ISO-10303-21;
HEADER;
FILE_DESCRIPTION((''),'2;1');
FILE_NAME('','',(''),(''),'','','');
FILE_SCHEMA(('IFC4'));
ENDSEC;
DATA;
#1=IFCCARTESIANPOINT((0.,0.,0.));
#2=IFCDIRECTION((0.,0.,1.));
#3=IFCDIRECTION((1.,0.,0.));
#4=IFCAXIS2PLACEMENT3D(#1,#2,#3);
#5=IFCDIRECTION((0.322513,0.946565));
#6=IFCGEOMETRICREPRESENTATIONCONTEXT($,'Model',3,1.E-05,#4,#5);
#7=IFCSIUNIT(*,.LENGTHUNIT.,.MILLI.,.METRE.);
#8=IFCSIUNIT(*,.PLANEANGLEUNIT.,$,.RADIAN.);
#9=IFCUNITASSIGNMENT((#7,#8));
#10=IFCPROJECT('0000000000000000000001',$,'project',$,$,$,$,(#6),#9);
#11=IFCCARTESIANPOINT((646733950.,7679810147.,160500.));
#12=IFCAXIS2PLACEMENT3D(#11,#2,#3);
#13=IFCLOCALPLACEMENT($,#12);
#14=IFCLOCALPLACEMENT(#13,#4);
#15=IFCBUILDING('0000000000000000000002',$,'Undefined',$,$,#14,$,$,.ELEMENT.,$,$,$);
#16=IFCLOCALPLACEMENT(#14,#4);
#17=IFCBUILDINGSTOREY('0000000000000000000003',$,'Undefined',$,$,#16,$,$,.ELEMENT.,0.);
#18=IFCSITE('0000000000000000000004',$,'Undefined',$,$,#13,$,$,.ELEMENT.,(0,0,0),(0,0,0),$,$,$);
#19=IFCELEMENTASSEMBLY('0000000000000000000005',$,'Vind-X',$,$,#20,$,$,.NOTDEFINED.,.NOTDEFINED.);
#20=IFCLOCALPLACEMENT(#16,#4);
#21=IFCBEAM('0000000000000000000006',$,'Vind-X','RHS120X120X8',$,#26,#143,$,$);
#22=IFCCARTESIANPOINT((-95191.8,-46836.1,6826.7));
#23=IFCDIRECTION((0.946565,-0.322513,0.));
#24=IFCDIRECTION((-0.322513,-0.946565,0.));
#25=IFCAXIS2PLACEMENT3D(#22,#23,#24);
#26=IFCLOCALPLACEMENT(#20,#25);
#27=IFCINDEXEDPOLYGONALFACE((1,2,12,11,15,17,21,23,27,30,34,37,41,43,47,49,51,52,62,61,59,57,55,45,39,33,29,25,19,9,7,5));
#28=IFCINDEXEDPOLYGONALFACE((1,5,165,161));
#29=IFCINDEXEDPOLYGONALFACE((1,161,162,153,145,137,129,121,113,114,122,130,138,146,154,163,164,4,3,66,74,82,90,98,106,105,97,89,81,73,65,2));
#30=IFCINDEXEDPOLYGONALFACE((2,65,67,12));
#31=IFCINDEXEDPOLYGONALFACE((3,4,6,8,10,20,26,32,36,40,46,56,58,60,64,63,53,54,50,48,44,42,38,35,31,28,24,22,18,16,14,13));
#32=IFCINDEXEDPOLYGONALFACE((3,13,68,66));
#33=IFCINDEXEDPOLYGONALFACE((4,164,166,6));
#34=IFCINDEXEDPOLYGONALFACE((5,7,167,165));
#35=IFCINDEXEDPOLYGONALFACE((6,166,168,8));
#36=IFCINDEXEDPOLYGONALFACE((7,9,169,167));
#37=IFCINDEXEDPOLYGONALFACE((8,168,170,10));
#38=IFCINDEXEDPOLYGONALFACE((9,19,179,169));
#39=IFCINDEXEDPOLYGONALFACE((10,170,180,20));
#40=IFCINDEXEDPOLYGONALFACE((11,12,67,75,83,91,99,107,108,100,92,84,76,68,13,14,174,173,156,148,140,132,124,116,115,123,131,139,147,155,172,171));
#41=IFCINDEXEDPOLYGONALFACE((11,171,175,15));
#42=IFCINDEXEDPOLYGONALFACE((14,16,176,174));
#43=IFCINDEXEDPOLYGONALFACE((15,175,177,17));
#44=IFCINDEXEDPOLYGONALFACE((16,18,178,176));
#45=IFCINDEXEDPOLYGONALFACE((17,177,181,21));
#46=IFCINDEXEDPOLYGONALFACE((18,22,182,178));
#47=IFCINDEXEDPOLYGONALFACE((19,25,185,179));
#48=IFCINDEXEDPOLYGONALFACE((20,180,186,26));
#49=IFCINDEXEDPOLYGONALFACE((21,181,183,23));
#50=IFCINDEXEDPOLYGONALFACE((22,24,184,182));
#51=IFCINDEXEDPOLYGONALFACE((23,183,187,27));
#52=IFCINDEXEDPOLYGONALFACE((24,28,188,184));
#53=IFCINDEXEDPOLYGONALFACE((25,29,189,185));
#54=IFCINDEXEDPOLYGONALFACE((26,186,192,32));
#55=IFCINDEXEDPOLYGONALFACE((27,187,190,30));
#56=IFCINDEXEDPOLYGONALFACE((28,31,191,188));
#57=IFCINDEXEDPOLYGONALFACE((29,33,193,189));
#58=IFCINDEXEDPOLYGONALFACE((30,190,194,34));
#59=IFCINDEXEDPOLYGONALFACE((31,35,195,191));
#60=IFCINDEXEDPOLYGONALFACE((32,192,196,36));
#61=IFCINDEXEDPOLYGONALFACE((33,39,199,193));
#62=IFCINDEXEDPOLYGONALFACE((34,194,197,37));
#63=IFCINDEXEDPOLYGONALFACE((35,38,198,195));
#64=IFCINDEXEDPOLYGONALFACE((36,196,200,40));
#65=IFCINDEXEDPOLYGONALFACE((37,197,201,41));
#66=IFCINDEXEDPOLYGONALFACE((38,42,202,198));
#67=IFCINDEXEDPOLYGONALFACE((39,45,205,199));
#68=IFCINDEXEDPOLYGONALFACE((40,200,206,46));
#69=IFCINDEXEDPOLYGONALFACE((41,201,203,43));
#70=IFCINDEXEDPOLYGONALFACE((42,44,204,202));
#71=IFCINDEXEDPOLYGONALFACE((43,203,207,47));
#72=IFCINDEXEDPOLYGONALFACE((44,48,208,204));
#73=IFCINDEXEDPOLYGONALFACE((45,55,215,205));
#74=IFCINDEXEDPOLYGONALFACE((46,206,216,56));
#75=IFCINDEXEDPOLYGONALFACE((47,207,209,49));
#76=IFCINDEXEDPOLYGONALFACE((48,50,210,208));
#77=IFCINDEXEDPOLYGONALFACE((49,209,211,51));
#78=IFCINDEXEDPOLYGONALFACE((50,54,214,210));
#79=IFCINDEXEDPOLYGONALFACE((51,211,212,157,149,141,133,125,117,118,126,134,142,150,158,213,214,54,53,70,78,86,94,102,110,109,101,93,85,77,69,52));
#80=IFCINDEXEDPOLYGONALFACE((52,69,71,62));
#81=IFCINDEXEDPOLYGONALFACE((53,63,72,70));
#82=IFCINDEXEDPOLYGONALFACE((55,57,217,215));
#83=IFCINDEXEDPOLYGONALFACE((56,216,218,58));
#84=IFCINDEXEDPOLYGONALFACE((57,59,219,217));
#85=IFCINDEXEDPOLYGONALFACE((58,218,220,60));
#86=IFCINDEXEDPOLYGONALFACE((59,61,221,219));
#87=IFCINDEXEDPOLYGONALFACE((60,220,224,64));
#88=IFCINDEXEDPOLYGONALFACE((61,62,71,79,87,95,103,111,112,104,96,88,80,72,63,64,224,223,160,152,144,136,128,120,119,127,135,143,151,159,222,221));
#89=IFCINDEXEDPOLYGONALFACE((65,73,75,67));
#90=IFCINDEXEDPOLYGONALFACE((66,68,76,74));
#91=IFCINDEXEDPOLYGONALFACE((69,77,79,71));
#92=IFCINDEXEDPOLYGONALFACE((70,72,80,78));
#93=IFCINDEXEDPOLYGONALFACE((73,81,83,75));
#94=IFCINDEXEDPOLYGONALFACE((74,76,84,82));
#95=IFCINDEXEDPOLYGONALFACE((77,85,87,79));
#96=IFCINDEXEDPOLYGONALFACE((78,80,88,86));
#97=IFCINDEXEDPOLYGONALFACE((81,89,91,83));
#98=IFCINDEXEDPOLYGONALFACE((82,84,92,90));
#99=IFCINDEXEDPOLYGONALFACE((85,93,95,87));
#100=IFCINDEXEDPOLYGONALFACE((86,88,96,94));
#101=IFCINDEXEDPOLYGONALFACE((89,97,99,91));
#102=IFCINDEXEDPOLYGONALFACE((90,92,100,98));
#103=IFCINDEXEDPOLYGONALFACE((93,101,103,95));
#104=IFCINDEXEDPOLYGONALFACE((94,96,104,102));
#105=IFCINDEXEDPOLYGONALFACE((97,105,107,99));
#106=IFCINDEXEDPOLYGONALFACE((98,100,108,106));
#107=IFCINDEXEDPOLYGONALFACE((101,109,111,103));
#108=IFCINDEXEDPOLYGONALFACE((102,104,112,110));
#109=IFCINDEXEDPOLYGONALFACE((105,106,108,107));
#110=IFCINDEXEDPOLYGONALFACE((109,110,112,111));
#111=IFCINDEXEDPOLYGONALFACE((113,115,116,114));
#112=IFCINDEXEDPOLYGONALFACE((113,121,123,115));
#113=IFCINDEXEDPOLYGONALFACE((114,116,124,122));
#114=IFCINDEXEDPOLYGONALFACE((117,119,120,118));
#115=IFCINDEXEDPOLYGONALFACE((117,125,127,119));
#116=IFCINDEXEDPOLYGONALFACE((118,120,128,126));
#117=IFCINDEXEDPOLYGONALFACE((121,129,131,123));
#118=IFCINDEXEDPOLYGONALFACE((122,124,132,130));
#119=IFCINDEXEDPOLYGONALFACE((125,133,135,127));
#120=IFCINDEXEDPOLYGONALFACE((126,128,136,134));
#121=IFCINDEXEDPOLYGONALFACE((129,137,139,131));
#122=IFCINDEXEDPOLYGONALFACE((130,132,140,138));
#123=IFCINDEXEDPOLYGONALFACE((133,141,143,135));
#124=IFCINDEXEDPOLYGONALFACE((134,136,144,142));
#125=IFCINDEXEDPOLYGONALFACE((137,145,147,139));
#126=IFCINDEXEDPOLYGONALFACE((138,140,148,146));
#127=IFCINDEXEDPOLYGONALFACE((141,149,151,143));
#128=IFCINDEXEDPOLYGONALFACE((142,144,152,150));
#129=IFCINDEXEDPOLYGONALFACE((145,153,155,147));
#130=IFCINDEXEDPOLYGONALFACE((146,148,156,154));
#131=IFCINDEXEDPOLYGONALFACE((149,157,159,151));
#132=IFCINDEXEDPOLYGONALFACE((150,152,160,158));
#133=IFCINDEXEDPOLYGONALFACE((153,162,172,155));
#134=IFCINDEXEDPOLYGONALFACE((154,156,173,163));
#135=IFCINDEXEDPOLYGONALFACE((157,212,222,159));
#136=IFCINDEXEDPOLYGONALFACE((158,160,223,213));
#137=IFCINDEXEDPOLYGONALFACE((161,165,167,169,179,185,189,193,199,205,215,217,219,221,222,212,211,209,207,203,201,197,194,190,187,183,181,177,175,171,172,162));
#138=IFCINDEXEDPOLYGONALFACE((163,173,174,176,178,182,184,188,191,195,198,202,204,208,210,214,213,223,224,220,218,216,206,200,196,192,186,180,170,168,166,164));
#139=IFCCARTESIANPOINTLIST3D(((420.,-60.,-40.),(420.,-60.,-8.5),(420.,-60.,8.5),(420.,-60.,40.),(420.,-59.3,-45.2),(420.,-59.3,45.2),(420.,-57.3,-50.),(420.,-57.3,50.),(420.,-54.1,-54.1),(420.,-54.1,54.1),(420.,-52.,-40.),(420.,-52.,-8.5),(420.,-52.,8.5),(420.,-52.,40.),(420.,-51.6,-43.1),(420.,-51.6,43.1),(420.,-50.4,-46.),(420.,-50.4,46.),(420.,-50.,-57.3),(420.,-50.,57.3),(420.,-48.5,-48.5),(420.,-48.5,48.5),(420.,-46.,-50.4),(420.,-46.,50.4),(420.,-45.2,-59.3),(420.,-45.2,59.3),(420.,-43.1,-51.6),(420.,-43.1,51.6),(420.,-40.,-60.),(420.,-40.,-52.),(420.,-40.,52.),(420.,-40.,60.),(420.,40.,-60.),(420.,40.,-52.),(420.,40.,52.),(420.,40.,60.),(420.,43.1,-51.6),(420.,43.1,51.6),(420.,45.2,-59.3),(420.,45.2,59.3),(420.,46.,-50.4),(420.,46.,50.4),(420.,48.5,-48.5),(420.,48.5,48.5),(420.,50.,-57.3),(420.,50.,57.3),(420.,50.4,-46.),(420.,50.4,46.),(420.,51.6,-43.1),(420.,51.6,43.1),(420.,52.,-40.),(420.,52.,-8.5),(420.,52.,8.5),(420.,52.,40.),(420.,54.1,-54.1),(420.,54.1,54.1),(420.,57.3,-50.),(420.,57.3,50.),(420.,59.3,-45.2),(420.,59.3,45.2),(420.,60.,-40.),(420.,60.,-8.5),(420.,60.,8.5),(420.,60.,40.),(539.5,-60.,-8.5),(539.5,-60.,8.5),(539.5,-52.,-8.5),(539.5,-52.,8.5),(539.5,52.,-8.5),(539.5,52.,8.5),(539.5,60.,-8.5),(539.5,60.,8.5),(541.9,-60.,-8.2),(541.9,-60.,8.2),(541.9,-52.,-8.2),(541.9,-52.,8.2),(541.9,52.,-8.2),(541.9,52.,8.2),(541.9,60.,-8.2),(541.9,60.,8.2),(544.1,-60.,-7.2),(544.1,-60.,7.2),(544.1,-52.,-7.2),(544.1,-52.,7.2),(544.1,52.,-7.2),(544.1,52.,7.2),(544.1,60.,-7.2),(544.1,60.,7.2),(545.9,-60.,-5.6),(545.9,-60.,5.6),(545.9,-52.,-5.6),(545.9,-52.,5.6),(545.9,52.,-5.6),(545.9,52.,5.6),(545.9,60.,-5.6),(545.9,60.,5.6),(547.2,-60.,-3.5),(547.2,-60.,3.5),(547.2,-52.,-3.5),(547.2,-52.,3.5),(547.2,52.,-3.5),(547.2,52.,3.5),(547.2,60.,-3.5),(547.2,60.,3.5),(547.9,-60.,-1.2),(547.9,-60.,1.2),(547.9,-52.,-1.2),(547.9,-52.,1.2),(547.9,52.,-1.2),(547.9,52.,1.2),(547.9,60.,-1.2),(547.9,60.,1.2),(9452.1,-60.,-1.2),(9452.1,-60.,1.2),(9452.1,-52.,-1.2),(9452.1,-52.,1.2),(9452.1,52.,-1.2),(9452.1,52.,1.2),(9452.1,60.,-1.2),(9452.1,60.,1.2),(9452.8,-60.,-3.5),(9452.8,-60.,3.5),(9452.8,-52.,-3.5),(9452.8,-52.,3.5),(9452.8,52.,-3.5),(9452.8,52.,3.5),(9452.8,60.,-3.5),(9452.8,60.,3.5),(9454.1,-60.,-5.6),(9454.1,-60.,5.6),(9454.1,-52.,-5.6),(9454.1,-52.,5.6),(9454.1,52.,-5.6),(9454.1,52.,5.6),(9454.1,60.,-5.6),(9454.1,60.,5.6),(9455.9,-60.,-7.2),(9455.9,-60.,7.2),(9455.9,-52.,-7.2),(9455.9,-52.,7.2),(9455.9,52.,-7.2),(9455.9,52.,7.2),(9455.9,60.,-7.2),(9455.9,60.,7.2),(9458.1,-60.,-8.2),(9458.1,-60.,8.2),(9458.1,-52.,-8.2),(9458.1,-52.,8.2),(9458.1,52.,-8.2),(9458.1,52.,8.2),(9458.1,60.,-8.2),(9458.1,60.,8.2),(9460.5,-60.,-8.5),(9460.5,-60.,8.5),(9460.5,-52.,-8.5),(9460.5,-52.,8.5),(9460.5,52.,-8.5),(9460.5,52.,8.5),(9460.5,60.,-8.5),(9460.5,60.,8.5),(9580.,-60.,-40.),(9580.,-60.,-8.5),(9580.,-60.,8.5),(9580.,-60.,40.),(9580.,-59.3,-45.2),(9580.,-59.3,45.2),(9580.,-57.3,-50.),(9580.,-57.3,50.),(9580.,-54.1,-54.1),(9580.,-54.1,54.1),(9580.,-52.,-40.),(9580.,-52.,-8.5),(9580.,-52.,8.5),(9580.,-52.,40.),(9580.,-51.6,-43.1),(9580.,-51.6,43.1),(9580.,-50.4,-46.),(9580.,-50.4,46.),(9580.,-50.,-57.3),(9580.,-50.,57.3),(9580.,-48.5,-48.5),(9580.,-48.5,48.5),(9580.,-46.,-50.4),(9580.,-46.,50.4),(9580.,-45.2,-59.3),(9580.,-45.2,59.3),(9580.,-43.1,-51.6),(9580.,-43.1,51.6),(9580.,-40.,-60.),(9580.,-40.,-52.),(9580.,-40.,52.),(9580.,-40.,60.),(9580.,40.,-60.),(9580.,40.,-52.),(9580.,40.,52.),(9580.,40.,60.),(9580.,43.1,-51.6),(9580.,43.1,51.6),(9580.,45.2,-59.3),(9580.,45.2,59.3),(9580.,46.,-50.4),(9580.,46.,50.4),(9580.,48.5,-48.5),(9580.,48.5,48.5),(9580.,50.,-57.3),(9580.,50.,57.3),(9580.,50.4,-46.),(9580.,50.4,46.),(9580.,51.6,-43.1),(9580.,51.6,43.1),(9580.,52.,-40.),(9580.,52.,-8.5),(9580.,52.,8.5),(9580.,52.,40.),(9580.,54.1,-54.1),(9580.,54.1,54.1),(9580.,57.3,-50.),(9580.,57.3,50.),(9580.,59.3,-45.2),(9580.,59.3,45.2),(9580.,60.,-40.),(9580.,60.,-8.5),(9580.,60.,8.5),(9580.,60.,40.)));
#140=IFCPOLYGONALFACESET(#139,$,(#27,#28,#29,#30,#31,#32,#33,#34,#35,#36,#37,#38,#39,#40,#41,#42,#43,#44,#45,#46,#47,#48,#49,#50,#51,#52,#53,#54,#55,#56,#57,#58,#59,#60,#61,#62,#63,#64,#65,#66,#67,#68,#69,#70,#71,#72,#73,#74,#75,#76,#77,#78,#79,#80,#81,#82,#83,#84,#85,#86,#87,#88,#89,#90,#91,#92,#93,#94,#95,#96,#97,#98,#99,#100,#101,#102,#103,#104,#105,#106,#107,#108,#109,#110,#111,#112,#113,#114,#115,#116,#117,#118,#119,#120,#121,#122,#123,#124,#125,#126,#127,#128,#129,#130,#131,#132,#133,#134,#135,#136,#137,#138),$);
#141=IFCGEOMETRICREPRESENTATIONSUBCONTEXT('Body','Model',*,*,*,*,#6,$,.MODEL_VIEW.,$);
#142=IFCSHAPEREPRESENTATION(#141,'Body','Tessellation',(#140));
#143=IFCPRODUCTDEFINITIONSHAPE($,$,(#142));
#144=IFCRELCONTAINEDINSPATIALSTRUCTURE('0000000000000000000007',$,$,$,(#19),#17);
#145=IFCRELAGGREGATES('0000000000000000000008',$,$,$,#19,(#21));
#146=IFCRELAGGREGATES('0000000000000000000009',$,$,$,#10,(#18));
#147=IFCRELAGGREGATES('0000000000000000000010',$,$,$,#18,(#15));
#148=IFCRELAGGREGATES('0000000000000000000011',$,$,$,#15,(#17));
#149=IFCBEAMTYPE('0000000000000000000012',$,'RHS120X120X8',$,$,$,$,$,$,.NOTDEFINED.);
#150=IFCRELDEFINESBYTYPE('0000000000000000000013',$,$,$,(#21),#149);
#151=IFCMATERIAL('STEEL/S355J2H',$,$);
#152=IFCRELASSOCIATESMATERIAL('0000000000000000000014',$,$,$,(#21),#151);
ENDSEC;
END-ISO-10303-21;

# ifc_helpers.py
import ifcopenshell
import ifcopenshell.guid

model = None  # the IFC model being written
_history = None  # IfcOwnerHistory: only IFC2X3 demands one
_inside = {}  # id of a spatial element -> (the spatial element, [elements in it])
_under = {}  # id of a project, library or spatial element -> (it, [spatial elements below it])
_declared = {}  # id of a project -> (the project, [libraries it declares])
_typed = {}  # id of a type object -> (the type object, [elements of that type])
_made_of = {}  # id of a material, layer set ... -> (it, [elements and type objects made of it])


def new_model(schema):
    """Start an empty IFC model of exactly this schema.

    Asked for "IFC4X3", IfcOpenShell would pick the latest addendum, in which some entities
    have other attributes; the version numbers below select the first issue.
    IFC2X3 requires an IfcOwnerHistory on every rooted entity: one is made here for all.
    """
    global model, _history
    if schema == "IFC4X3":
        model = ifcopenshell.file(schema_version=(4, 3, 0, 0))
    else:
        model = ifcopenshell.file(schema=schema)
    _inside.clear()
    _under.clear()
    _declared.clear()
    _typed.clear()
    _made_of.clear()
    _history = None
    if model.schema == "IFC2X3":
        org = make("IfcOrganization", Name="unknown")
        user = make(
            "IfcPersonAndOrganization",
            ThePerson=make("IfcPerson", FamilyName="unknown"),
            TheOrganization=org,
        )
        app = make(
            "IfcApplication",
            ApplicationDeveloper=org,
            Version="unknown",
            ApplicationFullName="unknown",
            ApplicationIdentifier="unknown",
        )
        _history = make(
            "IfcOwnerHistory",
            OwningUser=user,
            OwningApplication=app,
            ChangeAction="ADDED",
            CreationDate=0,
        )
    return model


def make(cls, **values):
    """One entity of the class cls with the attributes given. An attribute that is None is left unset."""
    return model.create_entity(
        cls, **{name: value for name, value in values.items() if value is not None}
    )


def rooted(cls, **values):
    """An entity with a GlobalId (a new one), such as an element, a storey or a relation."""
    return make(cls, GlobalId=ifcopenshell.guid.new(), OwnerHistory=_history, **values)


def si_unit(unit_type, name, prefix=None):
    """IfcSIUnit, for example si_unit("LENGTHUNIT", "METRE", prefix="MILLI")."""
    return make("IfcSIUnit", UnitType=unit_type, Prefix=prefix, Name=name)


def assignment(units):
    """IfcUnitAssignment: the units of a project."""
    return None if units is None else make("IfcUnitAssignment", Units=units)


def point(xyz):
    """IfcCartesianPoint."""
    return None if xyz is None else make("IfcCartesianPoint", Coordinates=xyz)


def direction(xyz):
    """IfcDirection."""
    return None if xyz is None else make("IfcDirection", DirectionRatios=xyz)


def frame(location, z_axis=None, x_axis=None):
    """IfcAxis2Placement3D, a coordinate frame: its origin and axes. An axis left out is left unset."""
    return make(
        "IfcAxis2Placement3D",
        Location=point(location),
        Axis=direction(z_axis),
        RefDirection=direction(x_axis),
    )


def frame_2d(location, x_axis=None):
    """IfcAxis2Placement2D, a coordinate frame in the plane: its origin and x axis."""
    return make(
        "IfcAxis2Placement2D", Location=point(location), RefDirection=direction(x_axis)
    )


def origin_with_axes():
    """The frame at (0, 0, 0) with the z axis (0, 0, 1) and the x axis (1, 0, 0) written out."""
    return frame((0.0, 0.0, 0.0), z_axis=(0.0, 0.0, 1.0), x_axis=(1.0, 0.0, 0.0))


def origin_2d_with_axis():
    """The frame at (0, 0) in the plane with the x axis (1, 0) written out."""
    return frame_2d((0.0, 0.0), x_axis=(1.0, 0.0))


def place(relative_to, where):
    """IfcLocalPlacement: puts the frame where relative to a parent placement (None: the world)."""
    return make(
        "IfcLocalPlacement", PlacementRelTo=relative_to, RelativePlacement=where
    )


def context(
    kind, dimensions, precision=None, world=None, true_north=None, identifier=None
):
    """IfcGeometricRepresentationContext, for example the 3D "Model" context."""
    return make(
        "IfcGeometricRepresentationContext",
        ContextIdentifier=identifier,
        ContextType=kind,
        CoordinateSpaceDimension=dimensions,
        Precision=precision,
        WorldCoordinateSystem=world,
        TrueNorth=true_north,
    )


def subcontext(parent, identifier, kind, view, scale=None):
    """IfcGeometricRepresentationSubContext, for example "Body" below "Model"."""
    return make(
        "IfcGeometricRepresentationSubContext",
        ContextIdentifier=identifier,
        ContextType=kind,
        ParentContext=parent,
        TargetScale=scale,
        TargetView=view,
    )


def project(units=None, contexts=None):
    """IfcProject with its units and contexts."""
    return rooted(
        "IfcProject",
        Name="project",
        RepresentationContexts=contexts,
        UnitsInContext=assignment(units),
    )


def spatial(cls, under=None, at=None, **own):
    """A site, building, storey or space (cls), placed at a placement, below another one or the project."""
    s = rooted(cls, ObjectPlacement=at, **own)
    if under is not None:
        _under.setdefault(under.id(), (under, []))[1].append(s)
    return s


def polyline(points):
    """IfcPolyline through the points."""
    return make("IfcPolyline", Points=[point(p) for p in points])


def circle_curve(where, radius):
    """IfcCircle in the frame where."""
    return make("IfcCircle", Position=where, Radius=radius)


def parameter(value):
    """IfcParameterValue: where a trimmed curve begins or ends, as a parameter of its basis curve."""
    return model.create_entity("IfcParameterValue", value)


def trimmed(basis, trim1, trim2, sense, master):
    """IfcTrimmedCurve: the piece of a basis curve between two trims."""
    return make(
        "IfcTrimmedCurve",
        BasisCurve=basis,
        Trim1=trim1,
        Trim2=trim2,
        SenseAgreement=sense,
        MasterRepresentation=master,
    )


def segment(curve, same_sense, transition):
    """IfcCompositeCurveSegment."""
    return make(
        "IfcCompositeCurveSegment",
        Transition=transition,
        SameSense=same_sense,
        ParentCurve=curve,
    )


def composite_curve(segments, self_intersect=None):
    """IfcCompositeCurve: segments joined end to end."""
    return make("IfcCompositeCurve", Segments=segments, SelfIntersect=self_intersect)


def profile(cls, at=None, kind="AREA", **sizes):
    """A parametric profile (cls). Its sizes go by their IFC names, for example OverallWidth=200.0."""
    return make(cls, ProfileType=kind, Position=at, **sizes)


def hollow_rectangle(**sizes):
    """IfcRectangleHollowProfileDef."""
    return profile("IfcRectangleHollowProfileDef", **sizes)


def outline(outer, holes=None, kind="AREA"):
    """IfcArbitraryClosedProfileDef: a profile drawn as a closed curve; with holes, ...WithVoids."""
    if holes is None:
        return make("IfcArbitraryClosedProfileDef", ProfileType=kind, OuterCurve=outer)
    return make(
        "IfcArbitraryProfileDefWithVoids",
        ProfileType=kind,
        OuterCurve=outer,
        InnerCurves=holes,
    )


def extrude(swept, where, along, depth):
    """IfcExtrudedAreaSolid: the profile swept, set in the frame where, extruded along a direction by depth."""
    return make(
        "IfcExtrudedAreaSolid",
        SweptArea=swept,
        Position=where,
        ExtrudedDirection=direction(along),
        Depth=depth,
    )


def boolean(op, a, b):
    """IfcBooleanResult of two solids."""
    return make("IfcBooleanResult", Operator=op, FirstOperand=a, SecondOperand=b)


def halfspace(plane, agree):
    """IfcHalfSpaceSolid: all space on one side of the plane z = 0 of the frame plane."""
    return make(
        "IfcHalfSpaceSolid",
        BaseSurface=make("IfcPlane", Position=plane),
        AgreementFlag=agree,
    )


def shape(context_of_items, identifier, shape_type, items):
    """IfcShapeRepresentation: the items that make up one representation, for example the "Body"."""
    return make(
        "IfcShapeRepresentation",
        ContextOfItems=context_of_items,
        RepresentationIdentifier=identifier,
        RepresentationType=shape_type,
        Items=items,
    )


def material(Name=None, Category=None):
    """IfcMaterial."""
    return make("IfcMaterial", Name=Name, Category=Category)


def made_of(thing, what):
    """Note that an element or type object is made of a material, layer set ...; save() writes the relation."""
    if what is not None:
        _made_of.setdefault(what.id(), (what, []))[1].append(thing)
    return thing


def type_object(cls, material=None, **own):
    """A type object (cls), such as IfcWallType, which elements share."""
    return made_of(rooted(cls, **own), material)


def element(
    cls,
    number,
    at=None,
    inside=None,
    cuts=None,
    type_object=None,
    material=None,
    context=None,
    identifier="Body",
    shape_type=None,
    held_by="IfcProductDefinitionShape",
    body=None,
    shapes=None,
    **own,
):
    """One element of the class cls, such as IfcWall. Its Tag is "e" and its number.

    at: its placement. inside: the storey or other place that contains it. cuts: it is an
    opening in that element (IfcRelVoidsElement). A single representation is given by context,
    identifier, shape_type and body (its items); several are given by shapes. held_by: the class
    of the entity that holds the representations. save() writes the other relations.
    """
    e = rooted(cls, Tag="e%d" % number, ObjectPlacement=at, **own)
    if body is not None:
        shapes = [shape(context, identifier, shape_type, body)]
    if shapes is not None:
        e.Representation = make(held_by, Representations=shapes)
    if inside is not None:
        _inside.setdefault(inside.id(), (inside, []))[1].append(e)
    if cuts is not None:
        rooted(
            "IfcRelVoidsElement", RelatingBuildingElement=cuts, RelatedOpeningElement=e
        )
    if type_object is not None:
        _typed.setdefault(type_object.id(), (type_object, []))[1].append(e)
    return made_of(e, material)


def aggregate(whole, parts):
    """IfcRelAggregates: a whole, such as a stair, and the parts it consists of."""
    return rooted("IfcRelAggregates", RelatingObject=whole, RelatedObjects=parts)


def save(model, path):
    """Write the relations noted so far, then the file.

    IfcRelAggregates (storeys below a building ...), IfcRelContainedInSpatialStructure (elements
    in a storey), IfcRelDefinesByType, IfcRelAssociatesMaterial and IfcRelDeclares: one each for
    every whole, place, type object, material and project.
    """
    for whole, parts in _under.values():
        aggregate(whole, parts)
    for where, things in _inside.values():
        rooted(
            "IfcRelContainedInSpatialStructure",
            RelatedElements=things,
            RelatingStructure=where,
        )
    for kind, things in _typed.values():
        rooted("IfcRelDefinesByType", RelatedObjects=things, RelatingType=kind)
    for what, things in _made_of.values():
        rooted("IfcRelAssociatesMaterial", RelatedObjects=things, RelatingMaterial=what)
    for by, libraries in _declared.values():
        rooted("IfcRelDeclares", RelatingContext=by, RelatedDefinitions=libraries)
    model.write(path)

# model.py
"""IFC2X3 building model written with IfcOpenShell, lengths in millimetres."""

from ifc_helpers import new_model, si_unit, direction, frame, frame_2d, origin_with_axes, origin_2d_with_axis, place, context, subcontext, project, spatial, polyline, circle_curve, parameter, trimmed, segment, composite_curve, hollow_rectangle, outline, extrude, boolean, halfspace, material, type_object, element, aggregate, save


model = new_model("IFC2X3")

# Units and contexts
model_context = context("Model", 3, precision=1e-05, world=origin_with_axes(), true_north=direction((0.322513, 0.946565)))
body_context = subcontext(model_context, "Body", "Model", "MODEL_VIEW")
ifc_project = project(units=[si_unit("LENGTHUNIT", "METRE", prefix="MILLI"), si_unit("PLANEANGLEUNIT", "RADIAN")], contexts=[model_context])

# Site, building, storey
site_placement = place(None, frame((646733950.0, 7679810147.0, 160500.0), z_axis=(0.0, 0.0, 1.0), x_axis=(1.0, 0.0, 0.0)))
site = spatial("IfcSite", under=ifc_project, at=site_placement, Name="Undefined", CompositionType="ELEMENT", RefLatitude=(0, 0, 0), RefLongitude=(0, 0, 0))
building_placement = place(site_placement, origin_with_axes())
building = spatial("IfcBuilding", under=site, at=building_placement, Name="Undefined", CompositionType="ELEMENT")
storey_placement = place(building_placement, origin_with_axes())
storey = spatial("IfcBuildingStorey", under=building, at=storey_placement, Name="Undefined", CompositionType="ELEMENT", Elevation=0.0)

# Shared definitions
ifc_material_1 = material(Name="STEEL/S355J2H")

# Element assembly, beam
assembly_1_placement = place(storey_placement, origin_with_axes())
assembly_1 = element("IfcElementAssembly", 1, at=assembly_1_placement, inside=storey, Name="Vind-X", AssemblyPlace="NOTDEFINED", PredefinedType="NOTDEFINED")
beam_type_1 = type_object("IfcBeamType", Name="RHS120X120X8", PredefinedType="NOTDEFINED")
beam_1_placement = place(assembly_1_placement, frame((-95191.8, -46836.1, 6826.7), z_axis=(0.946565, -0.322513, 0.0), x_axis=(-0.322513, -0.946565, 0.0)))
beam_1 = element("IfcBeam", 2, at=beam_1_placement, type_object=beam_type_1, material=ifc_material_1, Name="Vind-X", Description="RHS120X120X8", context=body_context, shape_type="CSG", body=[
    boolean("DIFFERENCE", boolean("DIFFERENCE", boolean("DIFFERENCE", boolean("DIFFERENCE", extrude(hollow_rectangle(XDim=120.0, YDim=120.0, WallThickness=8.0, InnerFilletRadius=12.0, OuterFilletRadius=20.0, at=origin_2d_with_axis()), frame((10000.0, 0.0, 0.0), z_axis=(-1.0, 0.0, 0.0), x_axis=(0.0, -1.0, 0.0)), (0.0, 0.0, 1.0), 10000.0), extrude(outline(composite_curve([segment(trimmed(circle_curve(frame_2d((8.5, 8.5), x_axis=(-1.0, 0.0)), 8.5), [parameter(0.0)], [parameter(1.570796)], True, "PARAMETER"), True, "CONTINUOUS"), segment(polyline([(8.5, 0.0), (133.0, 0.0), (133.0, 17.0), (8.5, 17.0)]), True, "CONTINUOUS"), segment(trimmed(circle_curve(frame_2d((8.5, 8.5), x_axis=(0.0, 1.0)), 8.5), [parameter(0.0)], [parameter(1.570796)], True, "PARAMETER"), True, "CONTINUOUS"), segment(polyline([(0.0, 8.5), (0.0, 8.5)]), True, "CONTINUOUS")], self_intersect=True)), frame((548.0, 62.2, 8.5), z_axis=(0.0, -1.0, 0.0), x_axis=(-1.0, 0.0, 0.0)), (0.0, 0.0, 1.0), 124.5)), extrude(outline(composite_curve([segment(trimmed(circle_curve(frame_2d((8.5, 8.5), x_axis=(-1.0, 0.0)), 8.5), [parameter(0.0)], [parameter(1.570796)], True, "PARAMETER"), True, "CONTINUOUS"), segment(polyline([(8.5, 0.0), (133.0, 0.0), (133.0, 17.0), (8.5, 17.0)]), True, "CONTINUOUS"), segment(trimmed(circle_curve(frame_2d((8.5, 8.5), x_axis=(0.0, 1.0)), 8.5), [parameter(0.0)], [parameter(1.570796)], True, "PARAMETER"), True, "CONTINUOUS"), segment(polyline([(0.0, 8.5), (0.0, 8.5)]), True, "CONTINUOUS")], self_intersect=True)), frame((9452.0, -62.2, 8.5), z_axis=(0.0, 1.0, 0.0), x_axis=(1.0, 0.0, 0.0)), (0.0, 0.0, 1.0), 124.5)), halfspace(frame((9580.0, 0.0, -1000.0), z_axis=(-1.0, 0.0, 0.0), x_axis=(0.0, 1.0, 0.0)), True)), halfspace(frame((420.0, 0.0, -1000.0), z_axis=(1.0, 0.0, 0.0), x_axis=(0.0, -1.0, 0.0)), True)),
])

aggregate(assembly_1, [beam_1])

save(model, "model.ifc")
